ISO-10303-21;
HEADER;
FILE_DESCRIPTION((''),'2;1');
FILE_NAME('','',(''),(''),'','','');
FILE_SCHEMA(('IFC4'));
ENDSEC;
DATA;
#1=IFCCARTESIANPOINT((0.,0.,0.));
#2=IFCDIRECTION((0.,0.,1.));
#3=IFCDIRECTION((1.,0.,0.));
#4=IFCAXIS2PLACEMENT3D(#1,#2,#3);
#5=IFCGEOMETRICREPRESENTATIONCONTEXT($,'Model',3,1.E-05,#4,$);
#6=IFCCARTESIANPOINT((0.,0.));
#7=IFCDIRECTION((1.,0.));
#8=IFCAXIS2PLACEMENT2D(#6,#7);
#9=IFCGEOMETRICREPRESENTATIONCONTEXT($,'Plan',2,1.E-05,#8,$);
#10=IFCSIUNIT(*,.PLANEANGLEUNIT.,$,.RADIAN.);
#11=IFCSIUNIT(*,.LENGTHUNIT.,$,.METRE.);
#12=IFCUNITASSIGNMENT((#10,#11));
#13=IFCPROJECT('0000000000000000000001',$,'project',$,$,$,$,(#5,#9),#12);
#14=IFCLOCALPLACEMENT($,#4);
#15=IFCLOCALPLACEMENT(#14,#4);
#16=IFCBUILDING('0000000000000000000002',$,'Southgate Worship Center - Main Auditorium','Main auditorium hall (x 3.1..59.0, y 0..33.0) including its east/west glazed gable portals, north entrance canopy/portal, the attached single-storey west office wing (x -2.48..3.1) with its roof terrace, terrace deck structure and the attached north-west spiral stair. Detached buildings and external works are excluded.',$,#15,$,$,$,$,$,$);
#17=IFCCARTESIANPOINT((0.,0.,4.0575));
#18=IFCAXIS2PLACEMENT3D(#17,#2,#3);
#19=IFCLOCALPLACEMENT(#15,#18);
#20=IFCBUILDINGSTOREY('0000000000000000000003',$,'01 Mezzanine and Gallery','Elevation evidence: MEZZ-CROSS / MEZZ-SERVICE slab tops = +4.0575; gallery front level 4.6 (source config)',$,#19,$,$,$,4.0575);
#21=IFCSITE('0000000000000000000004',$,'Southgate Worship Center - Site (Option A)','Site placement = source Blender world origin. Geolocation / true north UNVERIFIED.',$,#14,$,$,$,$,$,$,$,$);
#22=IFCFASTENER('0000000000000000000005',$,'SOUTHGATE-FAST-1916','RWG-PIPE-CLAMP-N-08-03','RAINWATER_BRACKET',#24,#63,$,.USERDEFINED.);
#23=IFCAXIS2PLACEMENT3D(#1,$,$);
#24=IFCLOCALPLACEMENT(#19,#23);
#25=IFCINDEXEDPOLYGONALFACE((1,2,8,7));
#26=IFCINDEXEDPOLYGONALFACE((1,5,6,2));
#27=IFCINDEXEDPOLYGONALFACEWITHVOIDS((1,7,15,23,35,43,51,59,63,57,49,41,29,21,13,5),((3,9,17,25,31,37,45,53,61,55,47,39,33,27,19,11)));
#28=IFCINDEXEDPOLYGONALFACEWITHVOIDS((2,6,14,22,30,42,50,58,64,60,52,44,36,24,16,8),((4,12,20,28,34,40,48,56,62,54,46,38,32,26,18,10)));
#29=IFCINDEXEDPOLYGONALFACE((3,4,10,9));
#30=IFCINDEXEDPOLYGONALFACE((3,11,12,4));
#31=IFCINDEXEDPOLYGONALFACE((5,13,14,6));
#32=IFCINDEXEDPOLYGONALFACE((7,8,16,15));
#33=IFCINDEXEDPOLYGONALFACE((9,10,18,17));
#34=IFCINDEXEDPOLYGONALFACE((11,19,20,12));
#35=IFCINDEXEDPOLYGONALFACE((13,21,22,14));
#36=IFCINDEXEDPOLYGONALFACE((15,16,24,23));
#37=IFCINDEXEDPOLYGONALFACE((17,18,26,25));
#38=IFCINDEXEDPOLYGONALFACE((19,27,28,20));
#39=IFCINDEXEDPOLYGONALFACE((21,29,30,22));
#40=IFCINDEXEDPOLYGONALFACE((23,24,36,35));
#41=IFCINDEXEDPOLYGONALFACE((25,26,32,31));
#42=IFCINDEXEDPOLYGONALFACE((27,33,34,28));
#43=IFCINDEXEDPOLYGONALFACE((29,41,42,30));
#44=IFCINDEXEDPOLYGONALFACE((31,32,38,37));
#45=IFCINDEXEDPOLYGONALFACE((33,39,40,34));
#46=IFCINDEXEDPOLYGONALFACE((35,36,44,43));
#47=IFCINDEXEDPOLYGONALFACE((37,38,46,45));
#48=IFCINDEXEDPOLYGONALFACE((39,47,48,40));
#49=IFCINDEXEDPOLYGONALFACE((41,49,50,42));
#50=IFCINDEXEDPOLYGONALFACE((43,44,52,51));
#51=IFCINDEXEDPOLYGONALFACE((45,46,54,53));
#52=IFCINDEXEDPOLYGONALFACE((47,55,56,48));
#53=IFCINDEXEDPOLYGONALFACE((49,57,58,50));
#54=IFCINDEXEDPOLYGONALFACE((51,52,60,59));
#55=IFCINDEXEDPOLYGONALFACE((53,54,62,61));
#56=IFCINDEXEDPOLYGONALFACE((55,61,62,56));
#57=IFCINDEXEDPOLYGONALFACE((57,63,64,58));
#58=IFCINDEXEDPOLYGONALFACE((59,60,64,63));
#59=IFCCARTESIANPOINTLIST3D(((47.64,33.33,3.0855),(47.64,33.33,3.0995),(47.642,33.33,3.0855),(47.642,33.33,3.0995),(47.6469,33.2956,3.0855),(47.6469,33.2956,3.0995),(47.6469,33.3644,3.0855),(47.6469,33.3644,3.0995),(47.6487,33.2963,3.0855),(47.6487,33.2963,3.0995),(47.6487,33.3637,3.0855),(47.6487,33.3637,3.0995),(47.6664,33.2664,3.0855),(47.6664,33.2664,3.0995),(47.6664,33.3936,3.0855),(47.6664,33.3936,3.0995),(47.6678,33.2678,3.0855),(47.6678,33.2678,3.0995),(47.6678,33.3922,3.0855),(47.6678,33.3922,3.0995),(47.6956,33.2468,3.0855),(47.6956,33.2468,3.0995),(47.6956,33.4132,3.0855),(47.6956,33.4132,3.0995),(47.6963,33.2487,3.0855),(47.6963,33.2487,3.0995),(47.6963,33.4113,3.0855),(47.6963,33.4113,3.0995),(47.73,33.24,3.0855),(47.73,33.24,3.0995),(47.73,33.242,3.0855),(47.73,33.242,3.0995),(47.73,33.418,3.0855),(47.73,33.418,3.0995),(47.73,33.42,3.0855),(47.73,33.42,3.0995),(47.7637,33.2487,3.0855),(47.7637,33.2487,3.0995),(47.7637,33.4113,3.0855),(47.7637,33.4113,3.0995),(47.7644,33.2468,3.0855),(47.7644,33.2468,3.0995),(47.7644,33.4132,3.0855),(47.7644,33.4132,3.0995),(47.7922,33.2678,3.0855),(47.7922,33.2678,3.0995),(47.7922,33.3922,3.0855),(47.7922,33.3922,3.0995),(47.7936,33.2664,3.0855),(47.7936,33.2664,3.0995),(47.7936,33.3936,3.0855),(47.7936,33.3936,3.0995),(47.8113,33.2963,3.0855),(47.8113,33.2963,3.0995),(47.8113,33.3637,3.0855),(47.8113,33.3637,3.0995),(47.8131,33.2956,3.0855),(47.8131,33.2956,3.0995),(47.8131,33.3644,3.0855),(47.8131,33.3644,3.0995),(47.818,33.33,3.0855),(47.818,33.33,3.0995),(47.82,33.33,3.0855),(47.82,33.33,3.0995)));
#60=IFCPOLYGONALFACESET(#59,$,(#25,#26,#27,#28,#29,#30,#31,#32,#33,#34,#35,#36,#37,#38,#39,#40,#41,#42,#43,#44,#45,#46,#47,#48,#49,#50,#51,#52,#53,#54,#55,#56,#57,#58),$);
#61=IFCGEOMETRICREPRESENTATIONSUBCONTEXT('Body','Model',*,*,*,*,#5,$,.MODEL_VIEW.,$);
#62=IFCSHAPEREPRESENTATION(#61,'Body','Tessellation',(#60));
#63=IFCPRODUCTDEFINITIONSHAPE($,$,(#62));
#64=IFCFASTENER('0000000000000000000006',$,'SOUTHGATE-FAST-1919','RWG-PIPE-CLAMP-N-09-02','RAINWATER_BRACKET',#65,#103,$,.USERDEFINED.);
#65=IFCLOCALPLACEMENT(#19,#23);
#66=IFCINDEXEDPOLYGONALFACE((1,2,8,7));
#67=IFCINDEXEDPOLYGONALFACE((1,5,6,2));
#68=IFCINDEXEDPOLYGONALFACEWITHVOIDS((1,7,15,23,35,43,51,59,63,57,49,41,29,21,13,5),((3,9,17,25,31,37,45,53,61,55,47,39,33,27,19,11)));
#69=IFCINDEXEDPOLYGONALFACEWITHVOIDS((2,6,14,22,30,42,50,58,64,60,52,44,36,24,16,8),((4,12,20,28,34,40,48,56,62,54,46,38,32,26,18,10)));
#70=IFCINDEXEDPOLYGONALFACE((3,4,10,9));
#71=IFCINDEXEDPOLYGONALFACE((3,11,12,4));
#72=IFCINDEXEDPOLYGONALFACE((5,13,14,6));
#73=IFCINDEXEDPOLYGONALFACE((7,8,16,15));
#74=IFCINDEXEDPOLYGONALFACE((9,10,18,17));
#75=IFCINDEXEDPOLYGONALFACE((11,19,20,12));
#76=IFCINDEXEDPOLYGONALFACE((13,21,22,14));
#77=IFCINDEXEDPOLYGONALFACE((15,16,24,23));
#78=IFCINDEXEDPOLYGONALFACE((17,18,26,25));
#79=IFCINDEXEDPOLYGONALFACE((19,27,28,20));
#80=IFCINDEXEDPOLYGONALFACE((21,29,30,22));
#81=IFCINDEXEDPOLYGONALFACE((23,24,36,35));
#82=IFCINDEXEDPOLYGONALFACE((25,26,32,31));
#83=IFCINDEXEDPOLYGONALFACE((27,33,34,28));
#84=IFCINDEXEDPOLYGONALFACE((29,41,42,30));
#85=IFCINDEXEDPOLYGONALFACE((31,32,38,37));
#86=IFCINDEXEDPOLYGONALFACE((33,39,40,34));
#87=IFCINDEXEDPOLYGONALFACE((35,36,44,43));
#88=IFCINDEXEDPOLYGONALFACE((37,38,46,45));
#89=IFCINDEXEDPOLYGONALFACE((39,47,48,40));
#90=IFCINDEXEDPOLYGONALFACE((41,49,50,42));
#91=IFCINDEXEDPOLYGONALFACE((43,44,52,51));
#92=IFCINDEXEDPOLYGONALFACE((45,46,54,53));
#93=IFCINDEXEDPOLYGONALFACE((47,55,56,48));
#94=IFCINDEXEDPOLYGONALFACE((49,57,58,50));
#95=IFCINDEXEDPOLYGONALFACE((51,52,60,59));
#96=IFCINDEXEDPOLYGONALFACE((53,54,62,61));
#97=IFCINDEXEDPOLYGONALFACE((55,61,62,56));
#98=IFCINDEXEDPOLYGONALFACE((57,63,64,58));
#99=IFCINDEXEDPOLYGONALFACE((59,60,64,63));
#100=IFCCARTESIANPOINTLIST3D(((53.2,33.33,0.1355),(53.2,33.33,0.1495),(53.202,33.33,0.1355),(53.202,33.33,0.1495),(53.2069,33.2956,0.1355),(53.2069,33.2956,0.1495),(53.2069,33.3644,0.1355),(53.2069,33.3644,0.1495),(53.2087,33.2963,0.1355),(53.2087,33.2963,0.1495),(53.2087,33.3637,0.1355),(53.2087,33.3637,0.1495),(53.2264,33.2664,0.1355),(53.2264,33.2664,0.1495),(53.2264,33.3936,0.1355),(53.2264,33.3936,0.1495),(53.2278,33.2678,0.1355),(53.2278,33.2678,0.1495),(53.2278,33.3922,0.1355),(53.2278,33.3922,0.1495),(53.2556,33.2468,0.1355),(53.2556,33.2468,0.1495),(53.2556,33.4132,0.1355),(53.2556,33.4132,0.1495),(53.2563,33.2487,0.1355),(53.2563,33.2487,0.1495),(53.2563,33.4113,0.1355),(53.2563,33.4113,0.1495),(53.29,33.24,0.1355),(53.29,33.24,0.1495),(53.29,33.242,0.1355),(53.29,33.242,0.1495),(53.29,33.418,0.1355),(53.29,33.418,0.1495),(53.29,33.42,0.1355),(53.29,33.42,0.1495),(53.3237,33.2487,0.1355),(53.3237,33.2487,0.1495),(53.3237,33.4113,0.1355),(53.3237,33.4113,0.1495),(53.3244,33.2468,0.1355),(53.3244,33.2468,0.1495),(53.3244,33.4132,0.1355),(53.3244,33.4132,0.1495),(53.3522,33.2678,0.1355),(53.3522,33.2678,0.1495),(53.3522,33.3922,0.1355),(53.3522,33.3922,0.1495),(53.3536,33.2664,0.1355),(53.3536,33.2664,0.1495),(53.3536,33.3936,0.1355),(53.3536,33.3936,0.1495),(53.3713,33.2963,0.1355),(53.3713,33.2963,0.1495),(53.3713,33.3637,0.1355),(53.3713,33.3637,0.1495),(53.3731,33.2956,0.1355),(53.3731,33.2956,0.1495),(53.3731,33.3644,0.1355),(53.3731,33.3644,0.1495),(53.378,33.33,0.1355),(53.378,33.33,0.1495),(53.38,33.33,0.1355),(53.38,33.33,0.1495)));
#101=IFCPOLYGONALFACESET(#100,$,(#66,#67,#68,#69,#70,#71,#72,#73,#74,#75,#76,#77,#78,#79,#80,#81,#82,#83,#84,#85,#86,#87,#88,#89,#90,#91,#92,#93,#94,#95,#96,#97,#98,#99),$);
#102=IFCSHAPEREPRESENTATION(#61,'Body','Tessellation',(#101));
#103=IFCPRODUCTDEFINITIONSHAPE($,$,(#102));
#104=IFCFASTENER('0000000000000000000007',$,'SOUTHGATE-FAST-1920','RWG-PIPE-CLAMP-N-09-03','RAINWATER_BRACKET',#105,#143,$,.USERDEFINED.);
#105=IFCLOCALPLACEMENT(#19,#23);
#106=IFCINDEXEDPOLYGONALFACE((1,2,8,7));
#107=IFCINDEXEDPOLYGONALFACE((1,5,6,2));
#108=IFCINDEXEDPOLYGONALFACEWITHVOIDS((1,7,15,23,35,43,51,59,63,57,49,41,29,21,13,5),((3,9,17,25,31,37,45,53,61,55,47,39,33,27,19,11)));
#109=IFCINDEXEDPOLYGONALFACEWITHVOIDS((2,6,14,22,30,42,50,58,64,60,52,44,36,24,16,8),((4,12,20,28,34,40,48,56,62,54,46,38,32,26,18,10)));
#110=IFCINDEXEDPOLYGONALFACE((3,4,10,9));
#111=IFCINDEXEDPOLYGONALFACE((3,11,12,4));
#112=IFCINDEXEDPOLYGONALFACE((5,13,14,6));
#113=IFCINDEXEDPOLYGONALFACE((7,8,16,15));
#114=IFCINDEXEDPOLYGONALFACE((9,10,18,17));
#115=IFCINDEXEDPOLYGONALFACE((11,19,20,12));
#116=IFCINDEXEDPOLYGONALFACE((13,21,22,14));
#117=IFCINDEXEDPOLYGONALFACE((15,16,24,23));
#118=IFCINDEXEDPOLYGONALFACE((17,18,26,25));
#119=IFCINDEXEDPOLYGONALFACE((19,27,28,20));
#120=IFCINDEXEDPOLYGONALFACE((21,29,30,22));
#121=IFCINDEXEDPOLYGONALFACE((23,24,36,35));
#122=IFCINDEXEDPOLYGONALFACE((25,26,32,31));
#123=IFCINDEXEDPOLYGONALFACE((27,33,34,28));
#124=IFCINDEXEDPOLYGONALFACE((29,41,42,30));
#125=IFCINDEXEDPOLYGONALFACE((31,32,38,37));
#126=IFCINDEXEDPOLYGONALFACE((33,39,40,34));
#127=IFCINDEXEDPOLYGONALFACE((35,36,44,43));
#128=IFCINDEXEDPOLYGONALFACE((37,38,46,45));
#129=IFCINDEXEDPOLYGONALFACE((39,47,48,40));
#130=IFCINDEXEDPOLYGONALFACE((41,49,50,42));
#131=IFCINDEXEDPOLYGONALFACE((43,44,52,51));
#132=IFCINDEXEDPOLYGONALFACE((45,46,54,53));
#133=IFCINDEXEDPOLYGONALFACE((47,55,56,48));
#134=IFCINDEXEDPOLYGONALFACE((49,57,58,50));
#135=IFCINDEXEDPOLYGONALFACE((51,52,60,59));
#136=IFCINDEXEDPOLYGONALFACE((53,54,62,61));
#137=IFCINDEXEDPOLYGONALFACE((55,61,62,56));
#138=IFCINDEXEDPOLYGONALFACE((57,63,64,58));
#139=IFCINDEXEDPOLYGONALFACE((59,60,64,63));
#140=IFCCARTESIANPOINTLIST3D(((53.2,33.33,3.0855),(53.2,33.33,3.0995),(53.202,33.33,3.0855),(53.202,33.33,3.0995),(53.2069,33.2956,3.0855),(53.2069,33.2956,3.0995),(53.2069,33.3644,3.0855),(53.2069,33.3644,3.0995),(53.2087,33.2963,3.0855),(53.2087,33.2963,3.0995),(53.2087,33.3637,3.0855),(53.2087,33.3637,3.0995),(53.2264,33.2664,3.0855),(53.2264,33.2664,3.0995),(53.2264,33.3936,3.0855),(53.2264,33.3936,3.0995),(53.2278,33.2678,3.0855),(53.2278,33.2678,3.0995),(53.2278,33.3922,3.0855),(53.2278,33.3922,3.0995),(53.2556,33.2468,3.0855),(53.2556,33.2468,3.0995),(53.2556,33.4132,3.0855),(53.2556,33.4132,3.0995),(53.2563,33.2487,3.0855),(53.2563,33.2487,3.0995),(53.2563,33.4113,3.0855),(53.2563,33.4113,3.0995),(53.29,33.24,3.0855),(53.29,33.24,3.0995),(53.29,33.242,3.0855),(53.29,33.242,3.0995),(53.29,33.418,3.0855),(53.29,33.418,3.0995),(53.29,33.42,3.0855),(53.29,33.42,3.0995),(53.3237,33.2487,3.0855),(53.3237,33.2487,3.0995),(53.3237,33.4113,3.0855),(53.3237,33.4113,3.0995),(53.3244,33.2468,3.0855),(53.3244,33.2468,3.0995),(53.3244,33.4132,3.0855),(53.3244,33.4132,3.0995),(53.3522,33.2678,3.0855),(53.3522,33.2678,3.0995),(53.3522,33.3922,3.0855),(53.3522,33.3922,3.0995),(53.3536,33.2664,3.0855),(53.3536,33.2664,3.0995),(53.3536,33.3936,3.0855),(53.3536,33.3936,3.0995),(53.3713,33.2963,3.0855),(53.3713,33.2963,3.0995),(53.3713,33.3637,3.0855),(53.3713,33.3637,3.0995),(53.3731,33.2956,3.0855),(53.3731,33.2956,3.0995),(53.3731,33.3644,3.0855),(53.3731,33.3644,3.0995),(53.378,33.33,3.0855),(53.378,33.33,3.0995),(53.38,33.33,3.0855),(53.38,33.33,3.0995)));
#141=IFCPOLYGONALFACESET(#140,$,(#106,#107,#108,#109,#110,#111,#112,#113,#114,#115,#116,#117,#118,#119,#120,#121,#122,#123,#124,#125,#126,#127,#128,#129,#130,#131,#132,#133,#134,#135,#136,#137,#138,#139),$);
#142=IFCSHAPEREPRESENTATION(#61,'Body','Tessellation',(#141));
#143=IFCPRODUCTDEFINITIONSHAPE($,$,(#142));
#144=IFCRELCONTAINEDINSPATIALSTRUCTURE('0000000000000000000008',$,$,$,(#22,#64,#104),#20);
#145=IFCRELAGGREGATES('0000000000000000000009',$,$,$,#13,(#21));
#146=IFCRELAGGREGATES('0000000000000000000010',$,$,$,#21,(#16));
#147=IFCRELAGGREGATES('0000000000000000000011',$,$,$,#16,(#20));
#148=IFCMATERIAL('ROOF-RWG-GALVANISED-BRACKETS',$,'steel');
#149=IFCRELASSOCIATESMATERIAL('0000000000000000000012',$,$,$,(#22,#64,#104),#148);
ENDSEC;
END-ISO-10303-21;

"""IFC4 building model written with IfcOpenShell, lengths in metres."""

from ifc_helpers import new_model, si_unit, frame, origin_with_axes, origin_2d_with_axis, place, context, subcontext, project, spatial, indexed_curve, outline, extrude, material, element, save


model = new_model("IFC4")

# Units and contexts
model_context = context("Model", 3, precision=1e-05, world=origin_with_axes())
plan_context = context("Plan", 2, precision=1e-05, world=origin_2d_with_axis())
body_context = subcontext(model_context, "Body", "Model", "MODEL_VIEW")
ifc_project = project(units=[si_unit("PLANEANGLEUNIT", "RADIAN"), si_unit("LENGTHUNIT", "METRE")], contexts=[model_context, plan_context])

# Site, building, storey
site_placement = place(None, origin_with_axes())
site = spatial("IfcSite", under=ifc_project, at=site_placement, Name="Southgate Worship Center - Site (Option A)", Description="Site placement = source Blender world origin. Geolocation / true north UNVERIFIED.")
building_placement = place(site_placement, origin_with_axes())
building = spatial("IfcBuilding", under=site, at=building_placement, Name="Southgate Worship Center - Main Auditorium", Description="Main auditorium hall (x 3.1..59.0, y 0..33.0) including its east/west glazed gable portals, north entrance canopy/portal, the attached single-storey west office wing (x -2.48..3.1) with its roof terrace, terrace deck structure and the attached north-west spiral stair. Detached buildings and external works are excluded.")
storey_placement = place(building_placement, frame((0.0, 0.0, 4.0575), z_axis=(0.0, 0.0, 1.0), x_axis=(1.0, 0.0, 0.0)))
storey = spatial("IfcBuildingStorey", under=building, at=storey_placement, Name="01 Mezzanine and Gallery", Description="Elevation evidence: MEZZ-CROSS / MEZZ-SERVICE slab tops = +4.0575; gallery front level 4.6 (source config)", Elevation=4.0575)

# Fasteners
ifc_material_1 = material(Name="ROOF-RWG-GALVANISED-BRACKETS", Category="steel")
fastener_1_placement = place(storey_placement, frame((47.64, 33.24, 3.0855), z_axis=(0.0, 0.0, 1.0), x_axis=(1.0, 0.0, 0.0)))
element("IfcFastener", 1, at=fastener_1_placement, inside=storey, material=ifc_material_1, Name="SOUTHGATE-FAST-1916", Description="RWG-PIPE-CLAMP-N-08-03", ObjectType="RAINWATER_BRACKET", PredefinedType="USERDEFINED", context=body_context, shape_type="SweptSolid", body=[
    extrude(outline(indexed_curve([(0.0, 0.0), (0.0069, 0.0344), (0.0, 0.0689), (-0.0195, 0.0981), (-0.0487, 0.1176), (-0.0831, 0.1244), (-0.1176, 0.1176), (-0.1468, 0.0981), (-0.1663, 0.0689), (-0.1731, 0.0344), (-0.1663, 0.0), (-0.1468, -0.0292), (-0.1176, -0.0487), (-0.0831, -0.0556), (-0.0487, -0.0487), (-0.0195, -0.0292), (0.0, 0.0)], self_intersect=False), holes=[indexed_curve([(-0.1454, -0.0278), (-0.1645, 0.0008), (-0.1712, 0.0344), (-0.1645, 0.0681), (-0.1454, 0.0967), (-0.1168, 0.1157), (-0.0831, 0.1224), (-0.0495, 0.1157), (-0.0209, 0.0967), (-0.0018, 0.0681), (0.0049, 0.0344), (-0.0018, 0.0008), (-0.0209, -0.0278), (-0.0495, -0.0469), (-0.0831, -0.0536), (-0.1168, -0.0469), (-0.1454, -0.0278)], self_intersect=False)]), frame((0.1731, 0.0556, 0.0), z_axis=(0.0, 0.0, 1.0), x_axis=(1.0, 0.0, 0.0)), (0.0, 0.0, 1.0), 0.014),
])
fastener_2_placement = place(storey_placement, frame((53.2, 33.24, 0.1355), z_axis=(0.0, 0.0, 1.0), x_axis=(1.0, 0.0, 0.0)))
element("IfcFastener", 2, at=fastener_2_placement, inside=storey, material=ifc_material_1, Name="SOUTHGATE-FAST-1919", Description="RWG-PIPE-CLAMP-N-09-02", ObjectType="RAINWATER_BRACKET", PredefinedType="USERDEFINED", context=body_context, shape_type="SweptSolid", body=[
    extrude(outline(indexed_curve([(0.0, 0.0), (0.0069, 0.0344), (0.0, 0.0689), (-0.0195, 0.0981), (-0.0487, 0.1176), (-0.0831, 0.1244), (-0.1176, 0.1176), (-0.1468, 0.0981), (-0.1663, 0.0689), (-0.1731, 0.0344), (-0.1663, 0.0), (-0.1468, -0.0292), (-0.1176, -0.0487), (-0.0831, -0.0556), (-0.0487, -0.0487), (-0.0195, -0.0292), (0.0, 0.0)], self_intersect=False), holes=[indexed_curve([(-0.1454, -0.0278), (-0.1645, 0.0008), (-0.1712, 0.0344), (-0.1645, 0.0681), (-0.1454, 0.0967), (-0.1168, 0.1157), (-0.0831, 0.1224), (-0.0495, 0.1157), (-0.0209, 0.0967), (-0.0018, 0.0681), (0.0049, 0.0344), (-0.0018, 0.0008), (-0.0209, -0.0278), (-0.0495, -0.0469), (-0.0831, -0.0536), (-0.1168, -0.0469), (-0.1454, -0.0278)], self_intersect=False)]), frame((0.1731, 0.0556, 0.0), z_axis=(0.0, 0.0, 1.0), x_axis=(1.0, 0.0, 0.0)), (0.0, 0.0, 1.0), 0.014),
])
fastener_3_placement = place(storey_placement, frame((53.2, 33.24, 3.0855), z_axis=(0.0, 0.0, 1.0), x_axis=(1.0, 0.0, 0.0)))
element("IfcFastener", 3, at=fastener_3_placement, inside=storey, material=ifc_material_1, Name="SOUTHGATE-FAST-1920", Description="RWG-PIPE-CLAMP-N-09-03", ObjectType="RAINWATER_BRACKET", PredefinedType="USERDEFINED", context=body_context, shape_type="SweptSolid", body=[
    extrude(outline(indexed_curve([(0.0, 0.0), (0.0069, 0.0344), (0.0, 0.0689), (-0.0195, 0.0981), (-0.0487, 0.1176), (-0.0831, 0.1244), (-0.1176, 0.1176), (-0.1468, 0.0981), (-0.1663, 0.0689), (-0.1731, 0.0344), (-0.1663, 0.0), (-0.1468, -0.0292), (-0.1176, -0.0487), (-0.0831, -0.0556), (-0.0487, -0.0487), (-0.0195, -0.0292), (0.0, 0.0)], self_intersect=False), holes=[indexed_curve([(-0.1454, -0.0278), (-0.1645, 0.0008), (-0.1712, 0.0344), (-0.1645, 0.0681), (-0.1454, 0.0967), (-0.1168, 0.1157), (-0.0831, 0.1224), (-0.0495, 0.1157), (-0.0209, 0.0967), (-0.0018, 0.0681), (0.0049, 0.0344), (-0.0018, 0.0008), (-0.0209, -0.0278), (-0.0495, -0.0469), (-0.0831, -0.0536), (-0.1168, -0.0469), (-0.1454, -0.0278)], self_intersect=False)]), frame((0.1731, 0.0556, 0.0), z_axis=(0.0, 0.0, 1.0), x_axis=(1.0, 0.0, 0.0)), (0.0, 0.0, 1.0), 0.014),
])

save(model, "model.ifc")
